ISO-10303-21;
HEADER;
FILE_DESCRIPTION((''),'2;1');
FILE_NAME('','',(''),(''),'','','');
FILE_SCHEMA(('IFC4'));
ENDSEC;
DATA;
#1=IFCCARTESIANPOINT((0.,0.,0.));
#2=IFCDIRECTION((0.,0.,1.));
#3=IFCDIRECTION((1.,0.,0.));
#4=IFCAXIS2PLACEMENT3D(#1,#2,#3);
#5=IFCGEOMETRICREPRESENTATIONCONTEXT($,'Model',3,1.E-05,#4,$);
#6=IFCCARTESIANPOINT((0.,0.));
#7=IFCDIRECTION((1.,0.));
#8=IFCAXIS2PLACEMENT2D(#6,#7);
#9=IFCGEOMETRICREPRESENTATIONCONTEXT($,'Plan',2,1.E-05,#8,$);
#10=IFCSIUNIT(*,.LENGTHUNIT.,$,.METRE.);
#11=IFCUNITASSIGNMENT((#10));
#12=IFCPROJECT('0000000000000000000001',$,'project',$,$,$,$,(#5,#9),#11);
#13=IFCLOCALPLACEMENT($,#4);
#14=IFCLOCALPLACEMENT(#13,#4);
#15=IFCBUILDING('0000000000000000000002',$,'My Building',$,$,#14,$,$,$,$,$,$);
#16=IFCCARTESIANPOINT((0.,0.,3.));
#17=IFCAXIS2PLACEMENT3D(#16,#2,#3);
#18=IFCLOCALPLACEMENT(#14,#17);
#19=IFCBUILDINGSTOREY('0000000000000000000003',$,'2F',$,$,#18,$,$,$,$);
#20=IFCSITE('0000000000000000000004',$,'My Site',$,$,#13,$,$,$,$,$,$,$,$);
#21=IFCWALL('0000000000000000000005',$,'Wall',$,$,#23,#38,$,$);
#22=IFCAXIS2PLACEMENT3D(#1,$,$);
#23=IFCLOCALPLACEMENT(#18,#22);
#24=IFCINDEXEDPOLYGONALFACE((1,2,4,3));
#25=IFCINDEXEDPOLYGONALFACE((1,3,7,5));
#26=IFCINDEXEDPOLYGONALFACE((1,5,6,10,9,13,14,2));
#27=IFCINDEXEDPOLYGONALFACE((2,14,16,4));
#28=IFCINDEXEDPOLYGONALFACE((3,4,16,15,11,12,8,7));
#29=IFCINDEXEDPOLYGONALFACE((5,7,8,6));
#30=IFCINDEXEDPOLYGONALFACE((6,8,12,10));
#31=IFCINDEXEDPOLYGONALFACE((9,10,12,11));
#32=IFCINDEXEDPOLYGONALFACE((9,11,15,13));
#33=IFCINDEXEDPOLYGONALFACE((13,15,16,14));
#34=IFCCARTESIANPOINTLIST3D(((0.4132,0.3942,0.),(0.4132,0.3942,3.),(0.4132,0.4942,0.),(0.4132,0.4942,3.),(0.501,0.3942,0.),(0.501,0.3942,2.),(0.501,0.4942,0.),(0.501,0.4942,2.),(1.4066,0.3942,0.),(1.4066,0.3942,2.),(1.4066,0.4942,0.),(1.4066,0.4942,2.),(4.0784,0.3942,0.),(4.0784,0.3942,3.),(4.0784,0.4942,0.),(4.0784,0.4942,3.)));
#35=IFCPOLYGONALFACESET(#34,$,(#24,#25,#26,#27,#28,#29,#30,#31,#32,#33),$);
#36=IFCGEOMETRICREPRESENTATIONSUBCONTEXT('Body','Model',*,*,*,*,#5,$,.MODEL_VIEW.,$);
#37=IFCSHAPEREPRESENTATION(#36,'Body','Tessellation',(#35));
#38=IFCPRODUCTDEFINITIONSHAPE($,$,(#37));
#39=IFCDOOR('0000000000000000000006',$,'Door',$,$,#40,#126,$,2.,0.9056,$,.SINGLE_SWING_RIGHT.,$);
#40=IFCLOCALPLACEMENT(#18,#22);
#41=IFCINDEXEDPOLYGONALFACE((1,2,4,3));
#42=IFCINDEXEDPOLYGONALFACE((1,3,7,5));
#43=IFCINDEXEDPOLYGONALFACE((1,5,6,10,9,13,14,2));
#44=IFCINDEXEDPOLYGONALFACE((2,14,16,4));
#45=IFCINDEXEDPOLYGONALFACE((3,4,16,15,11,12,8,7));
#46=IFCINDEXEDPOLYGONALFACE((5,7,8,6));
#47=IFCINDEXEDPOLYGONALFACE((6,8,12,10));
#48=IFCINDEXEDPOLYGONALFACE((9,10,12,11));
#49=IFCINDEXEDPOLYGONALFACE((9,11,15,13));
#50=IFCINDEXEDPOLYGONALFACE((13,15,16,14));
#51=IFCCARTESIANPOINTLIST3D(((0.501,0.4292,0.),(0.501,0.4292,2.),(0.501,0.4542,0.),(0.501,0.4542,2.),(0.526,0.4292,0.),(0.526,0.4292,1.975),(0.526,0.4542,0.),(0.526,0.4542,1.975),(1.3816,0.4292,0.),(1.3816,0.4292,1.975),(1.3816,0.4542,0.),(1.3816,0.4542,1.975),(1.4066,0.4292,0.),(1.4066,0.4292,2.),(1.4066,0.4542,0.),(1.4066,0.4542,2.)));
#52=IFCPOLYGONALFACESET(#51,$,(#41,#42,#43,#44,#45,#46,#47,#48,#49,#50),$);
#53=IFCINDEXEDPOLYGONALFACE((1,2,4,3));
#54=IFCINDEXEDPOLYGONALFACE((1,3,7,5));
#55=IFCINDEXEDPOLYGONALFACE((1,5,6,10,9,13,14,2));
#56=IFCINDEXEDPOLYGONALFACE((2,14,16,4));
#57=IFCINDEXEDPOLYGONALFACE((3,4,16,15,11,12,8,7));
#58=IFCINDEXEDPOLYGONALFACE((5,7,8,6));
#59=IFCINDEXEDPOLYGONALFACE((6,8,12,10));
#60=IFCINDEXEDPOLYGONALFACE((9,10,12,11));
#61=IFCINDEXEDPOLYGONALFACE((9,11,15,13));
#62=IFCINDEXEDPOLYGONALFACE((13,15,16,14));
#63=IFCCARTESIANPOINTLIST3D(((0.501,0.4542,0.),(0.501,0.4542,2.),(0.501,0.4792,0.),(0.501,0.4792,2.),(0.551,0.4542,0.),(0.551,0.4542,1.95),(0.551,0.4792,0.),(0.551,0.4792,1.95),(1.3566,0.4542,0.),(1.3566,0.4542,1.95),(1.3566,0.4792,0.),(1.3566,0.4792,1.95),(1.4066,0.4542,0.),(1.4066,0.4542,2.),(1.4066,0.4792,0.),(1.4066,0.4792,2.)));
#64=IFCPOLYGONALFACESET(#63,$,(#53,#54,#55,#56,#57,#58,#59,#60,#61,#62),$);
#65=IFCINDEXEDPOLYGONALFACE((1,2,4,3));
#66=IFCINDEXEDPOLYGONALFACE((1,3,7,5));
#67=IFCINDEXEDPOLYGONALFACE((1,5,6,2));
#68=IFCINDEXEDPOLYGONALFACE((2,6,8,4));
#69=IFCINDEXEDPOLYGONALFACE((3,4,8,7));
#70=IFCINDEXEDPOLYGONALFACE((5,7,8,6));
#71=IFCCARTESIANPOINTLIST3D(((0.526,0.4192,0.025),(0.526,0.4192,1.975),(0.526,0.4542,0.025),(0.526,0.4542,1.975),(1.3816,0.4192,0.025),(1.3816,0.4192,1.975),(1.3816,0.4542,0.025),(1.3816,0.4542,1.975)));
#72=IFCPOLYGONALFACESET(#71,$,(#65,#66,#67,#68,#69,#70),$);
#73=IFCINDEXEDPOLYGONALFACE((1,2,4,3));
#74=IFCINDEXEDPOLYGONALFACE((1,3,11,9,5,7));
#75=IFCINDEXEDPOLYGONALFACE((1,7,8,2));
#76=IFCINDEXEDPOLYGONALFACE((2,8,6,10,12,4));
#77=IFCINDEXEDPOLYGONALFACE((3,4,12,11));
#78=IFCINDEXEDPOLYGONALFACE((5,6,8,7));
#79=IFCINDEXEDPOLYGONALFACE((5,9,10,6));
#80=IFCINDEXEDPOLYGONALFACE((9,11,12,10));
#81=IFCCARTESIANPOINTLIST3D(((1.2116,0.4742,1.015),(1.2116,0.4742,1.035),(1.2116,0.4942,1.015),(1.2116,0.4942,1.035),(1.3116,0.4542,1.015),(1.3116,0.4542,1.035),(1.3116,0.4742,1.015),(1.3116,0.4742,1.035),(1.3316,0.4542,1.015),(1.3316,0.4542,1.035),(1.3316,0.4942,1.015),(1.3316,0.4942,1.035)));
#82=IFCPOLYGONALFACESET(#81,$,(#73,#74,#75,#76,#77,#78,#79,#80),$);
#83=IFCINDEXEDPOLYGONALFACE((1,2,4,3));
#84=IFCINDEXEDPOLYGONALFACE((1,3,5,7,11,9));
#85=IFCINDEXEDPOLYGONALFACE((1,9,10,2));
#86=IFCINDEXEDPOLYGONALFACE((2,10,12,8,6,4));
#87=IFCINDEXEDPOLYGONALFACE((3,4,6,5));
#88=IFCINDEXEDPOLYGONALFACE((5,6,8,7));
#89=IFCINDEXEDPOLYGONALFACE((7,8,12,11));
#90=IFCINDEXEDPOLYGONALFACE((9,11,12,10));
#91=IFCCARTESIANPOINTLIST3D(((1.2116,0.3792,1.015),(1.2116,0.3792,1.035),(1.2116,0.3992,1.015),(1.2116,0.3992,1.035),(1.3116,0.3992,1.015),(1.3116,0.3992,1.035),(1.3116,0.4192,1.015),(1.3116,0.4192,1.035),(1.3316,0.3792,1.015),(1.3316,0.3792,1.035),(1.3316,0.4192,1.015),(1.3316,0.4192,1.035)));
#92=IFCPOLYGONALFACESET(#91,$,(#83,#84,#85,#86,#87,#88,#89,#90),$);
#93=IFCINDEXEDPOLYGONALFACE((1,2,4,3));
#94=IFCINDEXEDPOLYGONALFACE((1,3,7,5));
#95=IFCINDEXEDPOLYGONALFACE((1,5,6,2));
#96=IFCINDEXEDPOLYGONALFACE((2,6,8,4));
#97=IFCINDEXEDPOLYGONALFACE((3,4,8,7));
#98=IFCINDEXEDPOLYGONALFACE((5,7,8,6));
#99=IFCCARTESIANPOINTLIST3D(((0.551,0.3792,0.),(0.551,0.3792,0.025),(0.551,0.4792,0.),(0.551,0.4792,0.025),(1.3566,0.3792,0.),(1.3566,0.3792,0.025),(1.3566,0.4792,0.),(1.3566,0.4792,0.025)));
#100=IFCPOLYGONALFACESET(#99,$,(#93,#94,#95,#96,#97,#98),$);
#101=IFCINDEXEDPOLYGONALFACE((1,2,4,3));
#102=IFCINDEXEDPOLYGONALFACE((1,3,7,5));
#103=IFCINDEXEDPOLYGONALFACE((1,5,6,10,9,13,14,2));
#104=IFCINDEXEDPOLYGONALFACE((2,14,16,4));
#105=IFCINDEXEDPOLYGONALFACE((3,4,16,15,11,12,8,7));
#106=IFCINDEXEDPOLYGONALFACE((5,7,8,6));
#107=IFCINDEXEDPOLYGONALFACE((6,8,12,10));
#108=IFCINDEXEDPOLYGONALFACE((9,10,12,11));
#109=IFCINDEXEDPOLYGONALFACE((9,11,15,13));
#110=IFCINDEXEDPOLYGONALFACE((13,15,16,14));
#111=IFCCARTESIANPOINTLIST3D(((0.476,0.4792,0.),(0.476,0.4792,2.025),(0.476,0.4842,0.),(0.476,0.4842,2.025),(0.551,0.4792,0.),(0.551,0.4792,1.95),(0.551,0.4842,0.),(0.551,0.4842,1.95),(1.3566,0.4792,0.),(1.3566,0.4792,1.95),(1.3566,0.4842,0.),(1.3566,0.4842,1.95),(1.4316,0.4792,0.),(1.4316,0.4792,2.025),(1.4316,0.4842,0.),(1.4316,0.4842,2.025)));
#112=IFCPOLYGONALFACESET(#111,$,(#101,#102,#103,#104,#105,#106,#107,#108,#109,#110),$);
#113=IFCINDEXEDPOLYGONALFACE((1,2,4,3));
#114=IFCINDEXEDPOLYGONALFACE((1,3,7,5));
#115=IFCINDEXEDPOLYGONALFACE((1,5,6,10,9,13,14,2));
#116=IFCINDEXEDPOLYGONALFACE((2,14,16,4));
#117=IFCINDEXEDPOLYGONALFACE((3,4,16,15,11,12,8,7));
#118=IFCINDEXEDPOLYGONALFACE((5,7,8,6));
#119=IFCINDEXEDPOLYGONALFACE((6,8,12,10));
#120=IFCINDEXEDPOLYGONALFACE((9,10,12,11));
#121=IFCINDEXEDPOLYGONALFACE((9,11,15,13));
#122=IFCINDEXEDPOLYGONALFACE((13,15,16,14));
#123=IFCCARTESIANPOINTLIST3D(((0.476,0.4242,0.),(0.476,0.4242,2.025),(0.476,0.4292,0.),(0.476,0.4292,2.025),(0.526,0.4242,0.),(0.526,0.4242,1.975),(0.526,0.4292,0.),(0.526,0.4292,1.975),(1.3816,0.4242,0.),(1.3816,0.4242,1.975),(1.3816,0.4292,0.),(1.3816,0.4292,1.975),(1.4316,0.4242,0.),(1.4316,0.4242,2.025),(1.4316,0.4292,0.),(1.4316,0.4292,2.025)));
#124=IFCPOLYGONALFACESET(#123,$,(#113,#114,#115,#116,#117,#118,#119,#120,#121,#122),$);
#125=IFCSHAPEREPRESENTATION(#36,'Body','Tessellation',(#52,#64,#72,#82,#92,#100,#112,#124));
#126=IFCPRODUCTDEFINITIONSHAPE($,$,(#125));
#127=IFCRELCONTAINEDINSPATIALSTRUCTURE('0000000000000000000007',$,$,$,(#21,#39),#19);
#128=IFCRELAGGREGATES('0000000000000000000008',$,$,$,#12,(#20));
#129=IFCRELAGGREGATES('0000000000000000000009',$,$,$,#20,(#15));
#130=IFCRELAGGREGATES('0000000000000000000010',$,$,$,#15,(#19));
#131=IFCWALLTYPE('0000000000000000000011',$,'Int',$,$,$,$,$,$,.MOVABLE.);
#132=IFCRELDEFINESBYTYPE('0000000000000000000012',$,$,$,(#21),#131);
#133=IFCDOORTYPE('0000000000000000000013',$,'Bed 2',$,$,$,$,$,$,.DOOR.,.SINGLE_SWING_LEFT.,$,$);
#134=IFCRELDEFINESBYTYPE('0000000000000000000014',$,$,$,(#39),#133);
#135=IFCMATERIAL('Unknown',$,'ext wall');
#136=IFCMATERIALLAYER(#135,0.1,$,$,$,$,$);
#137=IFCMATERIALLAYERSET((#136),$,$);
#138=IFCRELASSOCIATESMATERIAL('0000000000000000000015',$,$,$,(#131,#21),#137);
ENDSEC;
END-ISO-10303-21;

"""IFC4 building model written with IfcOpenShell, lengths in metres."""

from ifc_helpers import new_model, entity, si_unit, frame, origin_with_axes, origin_2d_with_axis, place, context, subcontext, project, spatial, line, indexed_curve, outline, extrude, shape, source, transform, mapped, material, layer, layer_set, layer_usage, type_object, type_shapes, element, fill, save


model = new_model("IFC4")

# Units and contexts
model_context = context("Model", 3, precision=1e-05, world=origin_with_axes())
plan_context = context("Plan", 2, precision=1e-05, world=origin_2d_with_axis())
body_context_1 = subcontext(model_context, "Body", "Model", "MODEL_VIEW")
body_context_2 = subcontext(plan_context, "Body", "Plan", "PLAN_VIEW")
ifc_project = project(units=[si_unit("LENGTHUNIT", "METRE")], contexts=[model_context, plan_context])

# Site, building, storey
site_placement = place(None, origin_with_axes())
site = spatial("IfcSite", under=ifc_project, at=site_placement, Name="My Site")
building_placement = place(site_placement, origin_with_axes())
building = spatial("IfcBuilding", under=site, at=building_placement, Name="My Building")
storey_placement = place(building_placement, frame((0.0, 0.0, 3.0), z_axis=(0.0, 0.0, 1.0), x_axis=(1.0, 0.0, 0.0)))
storey = spatial("IfcBuildingStorey", under=building, at=storey_placement, Name="2F")

# Shared definitions
ifc_material = material(Name="Unknown", Category="ext wall")

# Shared definitions
ifc_layer_1 = layer(ifc_material, 0.1)
ifc_layer_set_1 = layer_set([ifc_layer_1])
wall_type_1 = type_object("IfcWallType", Name="Int", PredefinedType="MOVABLE", material=ifc_layer_set_1)

# Wall, opening, door
ifc_layer_usage_1 = layer_usage(ifc_layer_set_1, "AXIS2", "POSITIVE", 0.0)
wall_1_placement = place(storey_placement, frame((0.4132, 0.3942, 0.0), z_axis=(0.0, 0.0, 1.0), x_axis=(1.0, 0.0, 0.0)))
wall_1 = element("IfcWall", 1, at=wall_1_placement, inside=storey, type_object=wall_type_1, material=ifc_layer_usage_1, Name="Wall", context=body_context_1, shape_type="SweptSolid", body=[
    extrude(outline(indexed_curve([(0.0, 0.0), (0.0, 0.1), (3.6652, 0.1), (3.6652, 0.0)], segments=[line(1, 2, 3, 4, 1)])), origin_with_axes(), (0.0, 0.0, 1.0), 3.0),
])
shared_shape_1 = source(origin_with_axes(), body_context_1, "Body", "SweptSolid", [
    extrude(outline(indexed_curve([(0.0, 0.0), (0.9056, 0.0), (0.9056, 2.0), (0.0, 2.0)], segments=[line(1, 2, 3, 4, 1)])), frame((0.0, -0.6, 0.0), z_axis=(0.0, -1.0, 0.0), x_axis=(1.0, 0.0, 0.0)), (0.0, 0.0, -1.0), 1.2),
])
opening_1_placement = place(wall_1_placement, frame((0.9934, 0.085, 0.0), z_axis=(0.0, 0.0, 1.0), x_axis=(-1.0, 0.0, 0.0)))
opening_1 = element("IfcOpeningElement", 2, at=opening_1_placement, cuts=wall_1, PredefinedType="OPENING", context=body_context_1, shape_type="MappedRepresentation", body=[
    mapped(shared_shape_1, transform((0.0, 0.0, 0.0), x_axis=(1.0, 0.0, 0.0), y_axis=(0.0, 1.0, 0.0), z_axis=(0.0, 0.0, 1.0), scale=1.0)),
])
door_type_1 = type_object("IfcDoorType", Name="Bed 2", OperationType="SINGLE_SWING_LEFT", PredefinedType="DOOR")
shared_shape_2 = source(origin_with_axes(), body_context_1, "Body", "SweptSolid", [
    extrude(outline(indexed_curve([(0.0, 0.0), (0.0, 2.0), (0.9056, 2.0), (0.9056, 0.0), (0.8806, 0.0), (0.8806, 1.975), (0.025, 1.975), (0.025, 0.0)], segments=[line(1, 2, 3, 4, 5, 6, 7, 8, 1)])), frame((0.0, 0.025, 0.0), z_axis=(0.0, -1.0, 0.0), x_axis=(1.0, 0.0, 0.0)), (0.0, 0.0, -1.0), 0.025),
    extrude(outline(indexed_curve([(0.0, 0.0), (0.0, 2.0), (0.9056, 2.0), (0.9056, 0.0), (0.8556, 0.0), (0.8556, 1.95), (0.05, 1.95), (0.05, 0.0)], segments=[line(1, 2, 3, 4, 5, 6, 7, 8, 1)])), frame((0.0, 0.0, 0.0), z_axis=(0.0, -1.0, 0.0), x_axis=(1.0, 0.0, 0.0)), (0.0, 0.0, -1.0), 0.025),
    extrude(outline(indexed_curve([(0.0, 0.0), (0.8556, 0.0), (0.8556, 0.035), (0.0, 0.035)], segments=[line(1, 2, 3, 4, 1)])), frame((0.025, 0.025, 0.025), z_axis=(0.0, 0.0, 1.0), x_axis=(1.0, 0.0, 0.0)), (0.0, 0.0, 1.0), 1.95),
    extrude(outline(indexed_curve([(0.0, 0.0), (0.0, -0.04), (0.12, -0.04), (0.12, -0.02), (0.02, -0.02), (0.02, 0.0)], segments=[line(1, 2, 3, 4, 5, 6, 1)])), frame((0.075, 0.025, 1.015), z_axis=(0.0, 0.0, 1.0), x_axis=(1.0, 0.0, 0.0)), (0.0, 0.0, 1.0), 0.02),
    extrude(outline(indexed_curve([(0.0, 0.0), (0.0, 0.04), (0.12, 0.04), (0.12, 0.02), (0.02, 0.02), (0.02, 0.0)], segments=[line(1, 2, 3, 4, 5, 6, 1)])), frame((0.075, 0.06, 1.015), z_axis=(0.0, 0.0, 1.0), x_axis=(1.0, 0.0, 0.0)), (0.0, 0.0, 1.0), 0.02),
    extrude(outline(indexed_curve([(0.0, 0.0), (0.8056, 0.0), (0.8056, 0.1), (0.0, 0.1)], segments=[line(1, 2, 3, 4, 1)])), frame((0.05, 0.0, 0.0), z_axis=(0.0, 0.0, 1.0), x_axis=(1.0, 0.0, 0.0)), (0.0, 0.0, 1.0), 0.025),
    extrude(outline(indexed_curve([(0.0, 0.0), (0.0, 2.025), (0.9556, 2.025), (0.9556, 0.0), (0.8806, 0.0), (0.8806, 1.95), (0.075, 1.95), (0.075, 0.0)], segments=[line(1, 2, 3, 4, 5, 6, 7, 8, 1)])), frame((-0.025, -0.005, 0.0), z_axis=(0.0, -1.0, 0.0), x_axis=(1.0, 0.0, 0.0)), (0.0, 0.0, -1.0), 0.005),
    extrude(outline(indexed_curve([(0.0, 0.0), (0.0, 2.025), (0.9556, 2.025), (0.9556, 0.0), (0.9056, 0.0), (0.9056, 1.975), (0.05, 1.975), (0.05, 0.0)], segments=[line(1, 2, 3, 4, 5, 6, 7, 8, 1)])), frame((-0.025, 0.05, 0.0), z_axis=(0.0, -1.0, 0.0), x_axis=(1.0, 0.0, 0.0)), (0.0, 0.0, -1.0), 0.005),
])
shared_shape_3 = source(origin_with_axes(), body_context_2, "Body", "Curve2D", [
    entity("IfcIndexedPolyCurve", entity("IfcCartesianPointList2D", [[0.0, 0.0], [0.0, 0.05], [0.025, 0.05], [0.025, 0.025], [0.05, 0.025], [0.05, 0.0]]), [entity("IfcLineIndex", [1, 2, 3, 4, 5, 6, 1])]),
    entity("IfcIndexedPolyCurve", entity("IfcCartesianPointList2D", [[0.9056, 0.0], [0.9056, 0.05], [0.8806, 0.05], [0.8806, 0.025], [0.8556, 0.025], [0.8556, 0.0]]), [entity("IfcLineIndex", [1, 2, 3, 4, 5, 6, 1])]),
    entity("IfcTrimmedCurve", entity("IfcEllipse", entity("IfcAxis2Placement2D", entity("IfcCartesianPoint", [0.8456, 0.05]), entity("IfcDirection", [1.0, 0.0])), 0.8206, 0.8556), [entity("IfcCartesianPoint", [0.8456, 0.9056])], [entity("IfcCartesianPoint", [0.025, 0.05])], True, "CARTESIAN"),
    entity("IfcIndexedPolyCurve", entity("IfcCartesianPointList2D", [[0.8806, 0.05], [0.8456, 0.05], [0.8456, 0.9056], [0.8806, 0.9056]]), [entity("IfcLineIndex", [1, 2, 3, 4, 1])]),
])
type_shapes(door_type_1, [shared_shape_2, shared_shape_3])
door_1_placement = place(opening_1_placement, origin_with_axes())
door_1 = element("IfcDoor", 3, at=door_1_placement, inside=storey, type_object=door_type_1, Name="Door", OperationType="SINGLE_SWING_RIGHT", OverallHeight=2.0, OverallWidth=0.9056, shapes=[
    shape(body_context_1, "Body", "MappedRepresentation", [mapped(shared_shape_2, transform((0.0, 0.0, 0.0), x_axis=(1.0, 0.0, 0.0), y_axis=(0.0, 1.0, 0.0), z_axis=(0.0, 0.0, 1.0), scale=1.0))]),
    shape(body_context_2, "Body", "MappedRepresentation", [mapped(shared_shape_3, transform((0.0, 0.0, 0.0), x_axis=(1.0, 0.0, 0.0), y_axis=(0.0, 1.0, 0.0), z_axis=(0.0, 0.0, 1.0), scale=1.0))]),
])
fill(opening_1, door_1)

save(model, "model.ifc")
